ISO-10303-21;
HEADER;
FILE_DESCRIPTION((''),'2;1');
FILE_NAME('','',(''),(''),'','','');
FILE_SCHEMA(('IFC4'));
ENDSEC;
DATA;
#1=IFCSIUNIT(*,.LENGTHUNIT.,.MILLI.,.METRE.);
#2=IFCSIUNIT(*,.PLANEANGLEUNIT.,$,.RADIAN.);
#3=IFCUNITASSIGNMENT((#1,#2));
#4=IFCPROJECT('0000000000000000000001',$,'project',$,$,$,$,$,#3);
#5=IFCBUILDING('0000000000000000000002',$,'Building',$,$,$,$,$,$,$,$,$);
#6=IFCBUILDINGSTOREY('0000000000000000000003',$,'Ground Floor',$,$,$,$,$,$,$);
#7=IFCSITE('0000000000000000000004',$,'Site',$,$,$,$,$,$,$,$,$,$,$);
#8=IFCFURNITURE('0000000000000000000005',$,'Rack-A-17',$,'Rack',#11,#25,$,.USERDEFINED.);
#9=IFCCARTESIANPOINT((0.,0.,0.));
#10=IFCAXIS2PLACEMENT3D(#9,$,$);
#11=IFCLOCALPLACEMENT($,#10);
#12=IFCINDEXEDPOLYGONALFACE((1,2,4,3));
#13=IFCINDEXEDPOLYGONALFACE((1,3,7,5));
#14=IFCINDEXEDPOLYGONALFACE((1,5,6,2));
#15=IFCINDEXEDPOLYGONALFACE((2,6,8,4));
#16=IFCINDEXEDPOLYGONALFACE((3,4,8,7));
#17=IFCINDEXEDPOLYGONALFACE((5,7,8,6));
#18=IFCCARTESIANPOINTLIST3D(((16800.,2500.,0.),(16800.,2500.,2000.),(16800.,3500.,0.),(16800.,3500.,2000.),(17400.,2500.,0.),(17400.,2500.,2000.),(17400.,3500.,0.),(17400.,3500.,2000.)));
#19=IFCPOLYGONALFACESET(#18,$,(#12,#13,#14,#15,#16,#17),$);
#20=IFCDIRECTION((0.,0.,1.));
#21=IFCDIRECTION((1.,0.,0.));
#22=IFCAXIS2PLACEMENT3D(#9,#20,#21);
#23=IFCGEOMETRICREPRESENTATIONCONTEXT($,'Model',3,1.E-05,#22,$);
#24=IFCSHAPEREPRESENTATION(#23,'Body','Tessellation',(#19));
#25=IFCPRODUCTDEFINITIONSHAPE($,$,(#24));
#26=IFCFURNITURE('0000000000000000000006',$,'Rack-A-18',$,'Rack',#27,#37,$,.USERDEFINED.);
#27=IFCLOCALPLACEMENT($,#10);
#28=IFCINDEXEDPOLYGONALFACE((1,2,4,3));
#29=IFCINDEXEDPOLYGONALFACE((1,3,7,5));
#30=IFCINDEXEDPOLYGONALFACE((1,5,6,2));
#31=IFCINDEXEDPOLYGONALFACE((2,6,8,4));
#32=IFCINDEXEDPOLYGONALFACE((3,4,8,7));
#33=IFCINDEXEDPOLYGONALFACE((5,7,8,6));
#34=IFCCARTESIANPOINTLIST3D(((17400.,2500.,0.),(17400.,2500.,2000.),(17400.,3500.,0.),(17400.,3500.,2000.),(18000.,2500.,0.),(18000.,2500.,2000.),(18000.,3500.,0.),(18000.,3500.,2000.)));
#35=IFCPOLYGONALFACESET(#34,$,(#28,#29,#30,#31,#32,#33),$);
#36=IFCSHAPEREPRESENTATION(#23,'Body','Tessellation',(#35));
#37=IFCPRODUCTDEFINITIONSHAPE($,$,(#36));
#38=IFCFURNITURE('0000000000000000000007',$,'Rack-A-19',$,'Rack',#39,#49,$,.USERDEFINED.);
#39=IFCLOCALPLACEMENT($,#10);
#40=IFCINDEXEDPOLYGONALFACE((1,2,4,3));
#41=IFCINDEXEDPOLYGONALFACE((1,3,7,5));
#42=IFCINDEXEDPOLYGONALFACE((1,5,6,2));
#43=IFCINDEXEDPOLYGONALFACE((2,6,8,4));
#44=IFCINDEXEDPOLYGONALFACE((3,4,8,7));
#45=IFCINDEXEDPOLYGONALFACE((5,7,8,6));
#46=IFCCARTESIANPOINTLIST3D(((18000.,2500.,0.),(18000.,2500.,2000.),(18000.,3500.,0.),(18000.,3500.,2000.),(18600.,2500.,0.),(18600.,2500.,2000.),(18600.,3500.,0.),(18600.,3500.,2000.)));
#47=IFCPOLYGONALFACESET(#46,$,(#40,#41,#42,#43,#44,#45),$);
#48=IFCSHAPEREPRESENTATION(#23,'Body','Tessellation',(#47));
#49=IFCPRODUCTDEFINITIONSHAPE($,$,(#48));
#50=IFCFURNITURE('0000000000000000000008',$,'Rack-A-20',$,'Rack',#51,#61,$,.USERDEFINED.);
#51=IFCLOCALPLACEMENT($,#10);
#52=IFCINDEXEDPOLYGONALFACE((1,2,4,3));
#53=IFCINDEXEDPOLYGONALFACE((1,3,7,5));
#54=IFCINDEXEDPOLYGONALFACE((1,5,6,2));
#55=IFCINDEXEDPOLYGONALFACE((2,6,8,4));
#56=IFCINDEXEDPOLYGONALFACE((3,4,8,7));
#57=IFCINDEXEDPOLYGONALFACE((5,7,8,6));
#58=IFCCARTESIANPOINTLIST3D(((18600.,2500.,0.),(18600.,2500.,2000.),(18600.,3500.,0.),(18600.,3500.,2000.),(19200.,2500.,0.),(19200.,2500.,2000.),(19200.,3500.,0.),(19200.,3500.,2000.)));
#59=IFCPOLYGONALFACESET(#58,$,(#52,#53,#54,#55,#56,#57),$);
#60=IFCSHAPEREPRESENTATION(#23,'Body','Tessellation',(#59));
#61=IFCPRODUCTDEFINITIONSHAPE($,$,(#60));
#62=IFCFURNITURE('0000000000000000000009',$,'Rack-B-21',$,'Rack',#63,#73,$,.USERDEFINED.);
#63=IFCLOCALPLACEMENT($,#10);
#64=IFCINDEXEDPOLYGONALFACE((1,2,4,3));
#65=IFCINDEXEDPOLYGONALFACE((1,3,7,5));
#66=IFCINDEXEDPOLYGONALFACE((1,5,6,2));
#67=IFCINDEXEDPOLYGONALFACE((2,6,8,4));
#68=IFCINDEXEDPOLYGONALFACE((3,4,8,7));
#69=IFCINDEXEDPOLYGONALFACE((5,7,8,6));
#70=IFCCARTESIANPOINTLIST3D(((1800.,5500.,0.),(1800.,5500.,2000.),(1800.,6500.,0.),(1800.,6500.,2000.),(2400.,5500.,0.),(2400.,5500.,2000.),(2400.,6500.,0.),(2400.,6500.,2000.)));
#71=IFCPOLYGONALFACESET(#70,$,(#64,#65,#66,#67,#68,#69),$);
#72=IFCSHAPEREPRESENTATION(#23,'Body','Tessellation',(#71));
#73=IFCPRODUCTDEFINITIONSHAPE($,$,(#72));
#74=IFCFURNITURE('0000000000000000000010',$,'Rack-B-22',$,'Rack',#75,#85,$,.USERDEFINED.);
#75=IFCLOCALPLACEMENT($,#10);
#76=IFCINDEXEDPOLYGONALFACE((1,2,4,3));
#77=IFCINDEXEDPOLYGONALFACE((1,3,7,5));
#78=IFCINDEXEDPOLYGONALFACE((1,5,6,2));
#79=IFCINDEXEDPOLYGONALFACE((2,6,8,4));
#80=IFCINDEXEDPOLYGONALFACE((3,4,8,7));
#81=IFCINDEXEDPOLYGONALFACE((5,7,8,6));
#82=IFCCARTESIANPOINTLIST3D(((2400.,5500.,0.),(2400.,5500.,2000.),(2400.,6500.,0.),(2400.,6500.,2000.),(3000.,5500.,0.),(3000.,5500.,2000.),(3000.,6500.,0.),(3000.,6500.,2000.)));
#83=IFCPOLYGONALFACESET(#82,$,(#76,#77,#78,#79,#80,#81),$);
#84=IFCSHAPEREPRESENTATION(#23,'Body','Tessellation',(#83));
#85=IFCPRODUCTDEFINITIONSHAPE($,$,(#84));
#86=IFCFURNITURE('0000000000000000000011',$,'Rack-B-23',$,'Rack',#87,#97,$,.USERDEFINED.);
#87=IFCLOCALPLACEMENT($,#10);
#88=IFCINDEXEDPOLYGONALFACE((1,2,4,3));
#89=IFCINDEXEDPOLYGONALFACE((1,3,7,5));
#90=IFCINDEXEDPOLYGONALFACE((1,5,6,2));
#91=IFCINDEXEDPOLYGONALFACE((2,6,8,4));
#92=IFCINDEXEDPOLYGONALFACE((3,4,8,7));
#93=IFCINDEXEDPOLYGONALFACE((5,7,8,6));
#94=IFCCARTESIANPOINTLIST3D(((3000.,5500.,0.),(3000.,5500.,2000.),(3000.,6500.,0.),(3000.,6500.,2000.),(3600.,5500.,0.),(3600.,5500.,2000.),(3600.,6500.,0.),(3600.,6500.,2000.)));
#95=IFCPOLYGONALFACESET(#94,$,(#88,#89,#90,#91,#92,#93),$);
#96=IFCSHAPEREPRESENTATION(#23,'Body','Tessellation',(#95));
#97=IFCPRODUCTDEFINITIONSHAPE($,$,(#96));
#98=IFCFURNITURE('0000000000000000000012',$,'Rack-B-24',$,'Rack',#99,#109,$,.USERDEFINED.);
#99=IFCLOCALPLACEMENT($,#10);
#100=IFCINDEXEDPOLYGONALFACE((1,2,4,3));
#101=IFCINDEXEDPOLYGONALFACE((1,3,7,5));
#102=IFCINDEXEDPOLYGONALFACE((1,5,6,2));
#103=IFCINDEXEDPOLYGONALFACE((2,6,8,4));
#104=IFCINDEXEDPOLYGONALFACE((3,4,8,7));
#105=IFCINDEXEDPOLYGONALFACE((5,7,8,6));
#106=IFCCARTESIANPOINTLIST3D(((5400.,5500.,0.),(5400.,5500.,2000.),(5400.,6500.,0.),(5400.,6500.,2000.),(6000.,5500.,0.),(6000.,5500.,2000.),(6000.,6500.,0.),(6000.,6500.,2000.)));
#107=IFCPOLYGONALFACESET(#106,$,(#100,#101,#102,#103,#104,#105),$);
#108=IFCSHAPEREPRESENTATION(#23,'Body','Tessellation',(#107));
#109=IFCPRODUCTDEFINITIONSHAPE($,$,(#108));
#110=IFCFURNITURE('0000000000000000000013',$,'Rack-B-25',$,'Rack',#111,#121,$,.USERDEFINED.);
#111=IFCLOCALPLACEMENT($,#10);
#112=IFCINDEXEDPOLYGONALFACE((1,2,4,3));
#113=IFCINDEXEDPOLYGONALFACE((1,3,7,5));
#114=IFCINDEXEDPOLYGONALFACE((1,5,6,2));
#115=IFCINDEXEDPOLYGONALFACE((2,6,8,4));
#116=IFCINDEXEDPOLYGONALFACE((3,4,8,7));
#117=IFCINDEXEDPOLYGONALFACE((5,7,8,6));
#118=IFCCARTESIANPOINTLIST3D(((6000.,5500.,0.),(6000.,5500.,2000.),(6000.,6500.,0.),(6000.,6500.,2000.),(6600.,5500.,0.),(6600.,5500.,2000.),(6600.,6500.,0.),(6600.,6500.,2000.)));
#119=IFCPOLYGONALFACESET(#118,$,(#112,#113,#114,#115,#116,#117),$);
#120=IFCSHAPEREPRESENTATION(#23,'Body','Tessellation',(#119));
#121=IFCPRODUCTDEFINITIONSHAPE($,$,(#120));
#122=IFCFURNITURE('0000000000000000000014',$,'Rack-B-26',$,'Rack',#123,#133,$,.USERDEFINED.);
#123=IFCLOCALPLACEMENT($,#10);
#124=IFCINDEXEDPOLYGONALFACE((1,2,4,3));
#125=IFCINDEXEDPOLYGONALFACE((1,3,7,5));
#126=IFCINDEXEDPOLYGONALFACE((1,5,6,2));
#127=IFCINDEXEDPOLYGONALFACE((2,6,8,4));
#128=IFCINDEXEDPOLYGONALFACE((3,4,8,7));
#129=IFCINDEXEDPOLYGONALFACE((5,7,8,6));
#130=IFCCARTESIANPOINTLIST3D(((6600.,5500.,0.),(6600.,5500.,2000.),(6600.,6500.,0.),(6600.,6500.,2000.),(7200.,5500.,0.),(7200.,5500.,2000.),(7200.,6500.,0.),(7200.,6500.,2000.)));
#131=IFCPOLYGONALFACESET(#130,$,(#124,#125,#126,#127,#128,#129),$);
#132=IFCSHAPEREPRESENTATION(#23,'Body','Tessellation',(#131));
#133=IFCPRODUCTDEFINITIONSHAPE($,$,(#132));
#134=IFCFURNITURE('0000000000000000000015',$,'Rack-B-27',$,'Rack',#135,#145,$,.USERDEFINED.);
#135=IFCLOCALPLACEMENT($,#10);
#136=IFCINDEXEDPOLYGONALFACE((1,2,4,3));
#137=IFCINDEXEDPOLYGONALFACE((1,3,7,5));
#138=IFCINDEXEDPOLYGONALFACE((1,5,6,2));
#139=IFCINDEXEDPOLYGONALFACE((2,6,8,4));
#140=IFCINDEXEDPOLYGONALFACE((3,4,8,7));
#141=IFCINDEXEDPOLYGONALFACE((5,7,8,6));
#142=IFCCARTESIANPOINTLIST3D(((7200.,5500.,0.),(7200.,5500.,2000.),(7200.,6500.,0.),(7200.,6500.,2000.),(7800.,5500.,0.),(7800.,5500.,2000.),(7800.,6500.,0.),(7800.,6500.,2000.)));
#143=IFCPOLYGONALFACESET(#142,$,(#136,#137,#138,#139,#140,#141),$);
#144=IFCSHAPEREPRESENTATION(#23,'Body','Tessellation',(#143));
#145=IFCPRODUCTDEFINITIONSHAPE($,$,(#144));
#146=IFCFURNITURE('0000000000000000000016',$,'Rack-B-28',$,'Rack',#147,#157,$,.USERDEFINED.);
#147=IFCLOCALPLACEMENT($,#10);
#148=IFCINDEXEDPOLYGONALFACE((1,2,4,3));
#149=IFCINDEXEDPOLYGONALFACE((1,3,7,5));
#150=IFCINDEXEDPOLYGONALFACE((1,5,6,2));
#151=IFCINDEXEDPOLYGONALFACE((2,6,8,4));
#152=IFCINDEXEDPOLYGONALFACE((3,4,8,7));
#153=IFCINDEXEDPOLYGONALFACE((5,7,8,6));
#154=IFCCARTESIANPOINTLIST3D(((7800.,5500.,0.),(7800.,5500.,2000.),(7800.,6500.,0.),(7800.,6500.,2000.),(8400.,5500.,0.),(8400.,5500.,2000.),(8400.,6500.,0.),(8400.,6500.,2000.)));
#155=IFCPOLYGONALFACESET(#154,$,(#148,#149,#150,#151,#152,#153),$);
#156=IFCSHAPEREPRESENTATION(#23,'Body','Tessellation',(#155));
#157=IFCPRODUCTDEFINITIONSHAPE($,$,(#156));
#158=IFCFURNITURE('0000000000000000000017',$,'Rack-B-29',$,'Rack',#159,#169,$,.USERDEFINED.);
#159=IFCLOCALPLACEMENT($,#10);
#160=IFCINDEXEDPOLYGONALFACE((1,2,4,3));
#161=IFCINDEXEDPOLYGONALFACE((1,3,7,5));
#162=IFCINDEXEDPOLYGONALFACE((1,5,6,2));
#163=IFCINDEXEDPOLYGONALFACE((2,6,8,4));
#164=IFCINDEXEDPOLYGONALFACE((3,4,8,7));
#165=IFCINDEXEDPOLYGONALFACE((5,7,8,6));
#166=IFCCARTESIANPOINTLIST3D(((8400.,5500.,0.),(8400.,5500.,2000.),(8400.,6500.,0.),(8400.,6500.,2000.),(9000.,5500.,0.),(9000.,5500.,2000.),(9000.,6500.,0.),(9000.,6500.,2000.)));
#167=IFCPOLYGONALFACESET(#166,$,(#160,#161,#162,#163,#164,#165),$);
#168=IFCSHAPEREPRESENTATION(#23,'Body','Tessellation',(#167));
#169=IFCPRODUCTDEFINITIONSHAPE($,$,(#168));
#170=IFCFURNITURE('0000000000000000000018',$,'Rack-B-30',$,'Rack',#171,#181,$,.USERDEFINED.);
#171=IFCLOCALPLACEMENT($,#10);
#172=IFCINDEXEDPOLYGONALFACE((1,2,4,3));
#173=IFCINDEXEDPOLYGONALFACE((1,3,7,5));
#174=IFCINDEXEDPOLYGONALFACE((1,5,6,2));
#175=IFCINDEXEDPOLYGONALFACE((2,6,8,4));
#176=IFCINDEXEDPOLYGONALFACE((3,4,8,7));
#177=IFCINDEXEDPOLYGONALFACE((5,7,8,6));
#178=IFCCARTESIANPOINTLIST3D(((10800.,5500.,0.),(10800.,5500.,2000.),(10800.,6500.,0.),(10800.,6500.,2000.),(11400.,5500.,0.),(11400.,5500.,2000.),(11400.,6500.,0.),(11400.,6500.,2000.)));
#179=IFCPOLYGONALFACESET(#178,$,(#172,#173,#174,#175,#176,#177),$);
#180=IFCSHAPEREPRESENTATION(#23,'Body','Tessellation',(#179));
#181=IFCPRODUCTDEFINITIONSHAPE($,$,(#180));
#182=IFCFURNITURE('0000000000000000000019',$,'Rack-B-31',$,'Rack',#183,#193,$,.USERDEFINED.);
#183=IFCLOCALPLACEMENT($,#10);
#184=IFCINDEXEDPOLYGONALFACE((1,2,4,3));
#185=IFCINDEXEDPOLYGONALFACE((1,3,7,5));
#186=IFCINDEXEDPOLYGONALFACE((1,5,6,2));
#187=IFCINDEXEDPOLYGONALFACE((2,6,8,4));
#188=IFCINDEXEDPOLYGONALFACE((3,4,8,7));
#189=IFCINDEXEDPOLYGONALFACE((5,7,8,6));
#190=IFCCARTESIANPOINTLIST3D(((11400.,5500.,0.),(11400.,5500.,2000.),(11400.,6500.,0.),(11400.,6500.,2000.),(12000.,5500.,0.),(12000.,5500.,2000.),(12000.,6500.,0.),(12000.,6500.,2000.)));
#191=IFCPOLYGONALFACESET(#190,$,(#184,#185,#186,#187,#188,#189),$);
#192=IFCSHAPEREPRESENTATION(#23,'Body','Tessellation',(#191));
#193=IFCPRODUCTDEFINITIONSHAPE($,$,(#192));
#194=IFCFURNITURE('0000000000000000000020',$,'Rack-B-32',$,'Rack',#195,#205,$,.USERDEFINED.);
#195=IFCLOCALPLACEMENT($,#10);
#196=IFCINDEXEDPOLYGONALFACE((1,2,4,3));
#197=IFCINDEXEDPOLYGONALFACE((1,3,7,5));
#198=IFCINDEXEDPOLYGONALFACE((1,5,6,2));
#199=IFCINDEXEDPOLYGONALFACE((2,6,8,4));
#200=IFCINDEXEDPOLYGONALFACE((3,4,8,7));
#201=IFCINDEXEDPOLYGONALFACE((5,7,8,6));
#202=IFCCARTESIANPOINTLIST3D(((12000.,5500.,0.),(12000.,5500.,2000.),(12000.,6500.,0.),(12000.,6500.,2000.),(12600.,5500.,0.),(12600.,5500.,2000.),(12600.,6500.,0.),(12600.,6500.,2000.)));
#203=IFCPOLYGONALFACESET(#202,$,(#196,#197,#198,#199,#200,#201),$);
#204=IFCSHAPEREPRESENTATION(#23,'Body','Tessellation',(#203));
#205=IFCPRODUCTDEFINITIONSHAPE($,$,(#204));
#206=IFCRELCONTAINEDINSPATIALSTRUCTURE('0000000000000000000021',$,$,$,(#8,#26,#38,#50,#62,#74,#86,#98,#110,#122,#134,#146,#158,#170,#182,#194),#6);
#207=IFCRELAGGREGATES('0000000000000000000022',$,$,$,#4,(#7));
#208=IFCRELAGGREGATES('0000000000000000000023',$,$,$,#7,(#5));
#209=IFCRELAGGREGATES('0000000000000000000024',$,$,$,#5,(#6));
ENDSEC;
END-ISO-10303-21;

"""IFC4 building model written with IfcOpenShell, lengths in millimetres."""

from ifc_helpers import new_model, si_unit, frame, origin_with_axes, place, context, project, spatial, rectangle, extrude, element, save


model = new_model("IFC4")

# Units and contexts
model_context = context("Model", 3, precision=1e-05, world=origin_with_axes())
ifc_project = project(units=[si_unit("LENGTHUNIT", "METRE", prefix="MILLI"), si_unit("PLANEANGLEUNIT", "RADIAN")])

# Site, building, storey
site = spatial("IfcSite", under=ifc_project, Name="Site")
building = spatial("IfcBuilding", under=site, Name="Building")
storey = spatial("IfcBuildingStorey", under=building, Name="Ground Floor")

# Furniture
furniture_1_placement = place(None, origin_with_axes())
element("IfcFurniture", 1, at=furniture_1_placement, inside=storey, Name="Rack-A-17", ObjectType="Rack", PredefinedType="USERDEFINED", context=model_context, shape_type="SweptSolid", body=[
    extrude(rectangle(XDim=600.0, YDim=1000.0), frame((17100.0, 3000.0, 0.0), z_axis=(0.0, 0.0, 1.0), x_axis=(1.0, 0.0, 0.0)), (0.0, 0.0, 1.0), 2000.0),
])
furniture_2_placement = place(None, origin_with_axes())
element("IfcFurniture", 2, at=furniture_2_placement, inside=storey, Name="Rack-A-18", ObjectType="Rack", PredefinedType="USERDEFINED", context=model_context, shape_type="SweptSolid", body=[
    extrude(rectangle(XDim=600.0, YDim=1000.0), frame((17700.0, 3000.0, 0.0), z_axis=(0.0, 0.0, 1.0), x_axis=(1.0, 0.0, 0.0)), (0.0, 0.0, 1.0), 2000.0),
])
furniture_3_placement = place(None, origin_with_axes())
element("IfcFurniture", 3, at=furniture_3_placement, inside=storey, Name="Rack-A-19", ObjectType="Rack", PredefinedType="USERDEFINED", context=model_context, shape_type="SweptSolid", body=[
    extrude(rectangle(XDim=600.0, YDim=1000.0), frame((18300.0, 3000.0, 0.0), z_axis=(0.0, 0.0, 1.0), x_axis=(1.0, 0.0, 0.0)), (0.0, 0.0, 1.0), 2000.0),
])
furniture_4_placement = place(None, origin_with_axes())
element("IfcFurniture", 4, at=furniture_4_placement, inside=storey, Name="Rack-A-20", ObjectType="Rack", PredefinedType="USERDEFINED", context=model_context, shape_type="SweptSolid", body=[
    extrude(rectangle(XDim=600.0, YDim=1000.0), frame((18900.0, 3000.0, 0.0), z_axis=(0.0, 0.0, 1.0), x_axis=(1.0, 0.0, 0.0)), (0.0, 0.0, 1.0), 2000.0),
])
furniture_5_placement = place(None, origin_with_axes())
element("IfcFurniture", 5, at=furniture_5_placement, inside=storey, Name="Rack-B-21", ObjectType="Rack", PredefinedType="USERDEFINED", context=model_context, shape_type="SweptSolid", body=[
    extrude(rectangle(XDim=600.0, YDim=1000.0), frame((2100.0, 6000.0, 0.0), z_axis=(0.0, 0.0, 1.0), x_axis=(1.0, 0.0, 0.0)), (0.0, 0.0, 1.0), 2000.0),
])
furniture_6_placement = place(None, origin_with_axes())
element("IfcFurniture", 6, at=furniture_6_placement, inside=storey, Name="Rack-B-22", ObjectType="Rack", PredefinedType="USERDEFINED", context=model_context, shape_type="SweptSolid", body=[
    extrude(rectangle(XDim=600.0, YDim=1000.0), frame((2700.0, 6000.0, 0.0), z_axis=(0.0, 0.0, 1.0), x_axis=(1.0, 0.0, 0.0)), (0.0, 0.0, 1.0), 2000.0),
])
furniture_7_placement = place(None, origin_with_axes())
element("IfcFurniture", 7, at=furniture_7_placement, inside=storey, Name="Rack-B-23", ObjectType="Rack", PredefinedType="USERDEFINED", context=model_context, shape_type="SweptSolid", body=[
    extrude(rectangle(XDim=600.0, YDim=1000.0), frame((3300.0, 6000.0, 0.0), z_axis=(0.0, 0.0, 1.0), x_axis=(1.0, 0.0, 0.0)), (0.0, 0.0, 1.0), 2000.0),
])
furniture_8_placement = place(None, origin_with_axes())
element("IfcFurniture", 8, at=furniture_8_placement, inside=storey, Name="Rack-B-24", ObjectType="Rack", PredefinedType="USERDEFINED", context=model_context, shape_type="SweptSolid", body=[
    extrude(rectangle(XDim=600.0, YDim=1000.0), frame((5700.0, 6000.0, 0.0), z_axis=(0.0, 0.0, 1.0), x_axis=(1.0, 0.0, 0.0)), (0.0, 0.0, 1.0), 2000.0),
])
furniture_9_placement = place(None, origin_with_axes())
element("IfcFurniture", 9, at=furniture_9_placement, inside=storey, Name="Rack-B-25", ObjectType="Rack", PredefinedType="USERDEFINED", context=model_context, shape_type="SweptSolid", body=[
    extrude(rectangle(XDim=600.0, YDim=1000.0), frame((6300.0, 6000.0, 0.0), z_axis=(0.0, 0.0, 1.0), x_axis=(1.0, 0.0, 0.0)), (0.0, 0.0, 1.0), 2000.0),
])
furniture_10_placement = place(None, origin_with_axes())
element("IfcFurniture", 10, at=furniture_10_placement, inside=storey, Name="Rack-B-26", ObjectType="Rack", PredefinedType="USERDEFINED", context=model_context, shape_type="SweptSolid", body=[
    extrude(rectangle(XDim=600.0, YDim=1000.0), frame((6900.0, 6000.0, 0.0), z_axis=(0.0, 0.0, 1.0), x_axis=(1.0, 0.0, 0.0)), (0.0, 0.0, 1.0), 2000.0),
])
furniture_11_placement = place(None, origin_with_axes())
element("IfcFurniture", 11, at=furniture_11_placement, inside=storey, Name="Rack-B-27", ObjectType="Rack", PredefinedType="USERDEFINED", context=model_context, shape_type="SweptSolid", body=[
    extrude(rectangle(XDim=600.0, YDim=1000.0), frame((7500.0, 6000.0, 0.0), z_axis=(0.0, 0.0, 1.0), x_axis=(1.0, 0.0, 0.0)), (0.0, 0.0, 1.0), 2000.0),
])
furniture_12_placement = place(None, origin_with_axes())
element("IfcFurniture", 12, at=furniture_12_placement, inside=storey, Name="Rack-B-28", ObjectType="Rack", PredefinedType="USERDEFINED", context=model_context, shape_type="SweptSolid", body=[
    extrude(rectangle(XDim=600.0, YDim=1000.0), frame((8100.0, 6000.0, 0.0), z_axis=(0.0, 0.0, 1.0), x_axis=(1.0, 0.0, 0.0)), (0.0, 0.0, 1.0), 2000.0),
])
furniture_13_placement = place(None, origin_with_axes())
element("IfcFurniture", 13, at=furniture_13_placement, inside=storey, Name="Rack-B-29", ObjectType="Rack", PredefinedType="USERDEFINED", context=model_context, shape_type="SweptSolid", body=[
    extrude(rectangle(XDim=600.0, YDim=1000.0), frame((8700.0, 6000.0, 0.0), z_axis=(0.0, 0.0, 1.0), x_axis=(1.0, 0.0, 0.0)), (0.0, 0.0, 1.0), 2000.0),
])
furniture_14_placement = place(None, origin_with_axes())
element("IfcFurniture", 14, at=furniture_14_placement, inside=storey, Name="Rack-B-30", ObjectType="Rack", PredefinedType="USERDEFINED", context=model_context, shape_type="SweptSolid", body=[
    extrude(rectangle(XDim=600.0, YDim=1000.0), frame((11100.0, 6000.0, 0.0), z_axis=(0.0, 0.0, 1.0), x_axis=(1.0, 0.0, 0.0)), (0.0, 0.0, 1.0), 2000.0),
])
furniture_15_placement = place(None, origin_with_axes())
element("IfcFurniture", 15, at=furniture_15_placement, inside=storey, Name="Rack-B-31", ObjectType="Rack", PredefinedType="USERDEFINED", context=model_context, shape_type="SweptSolid", body=[
    extrude(rectangle(XDim=600.0, YDim=1000.0), frame((11700.0, 6000.0, 0.0), z_axis=(0.0, 0.0, 1.0), x_axis=(1.0, 0.0, 0.0)), (0.0, 0.0, 1.0), 2000.0),
])
furniture_16_placement = place(None, origin_with_axes())
element("IfcFurniture", 16, at=furniture_16_placement, inside=storey, Name="Rack-B-32", ObjectType="Rack", PredefinedType="USERDEFINED", context=model_context, shape_type="SweptSolid", body=[
    extrude(rectangle(XDim=600.0, YDim=1000.0), frame((12300.0, 6000.0, 0.0), z_axis=(0.0, 0.0, 1.0), x_axis=(1.0, 0.0, 0.0)), (0.0, 0.0, 1.0), 2000.0),
])

save(model, "model.ifc")
